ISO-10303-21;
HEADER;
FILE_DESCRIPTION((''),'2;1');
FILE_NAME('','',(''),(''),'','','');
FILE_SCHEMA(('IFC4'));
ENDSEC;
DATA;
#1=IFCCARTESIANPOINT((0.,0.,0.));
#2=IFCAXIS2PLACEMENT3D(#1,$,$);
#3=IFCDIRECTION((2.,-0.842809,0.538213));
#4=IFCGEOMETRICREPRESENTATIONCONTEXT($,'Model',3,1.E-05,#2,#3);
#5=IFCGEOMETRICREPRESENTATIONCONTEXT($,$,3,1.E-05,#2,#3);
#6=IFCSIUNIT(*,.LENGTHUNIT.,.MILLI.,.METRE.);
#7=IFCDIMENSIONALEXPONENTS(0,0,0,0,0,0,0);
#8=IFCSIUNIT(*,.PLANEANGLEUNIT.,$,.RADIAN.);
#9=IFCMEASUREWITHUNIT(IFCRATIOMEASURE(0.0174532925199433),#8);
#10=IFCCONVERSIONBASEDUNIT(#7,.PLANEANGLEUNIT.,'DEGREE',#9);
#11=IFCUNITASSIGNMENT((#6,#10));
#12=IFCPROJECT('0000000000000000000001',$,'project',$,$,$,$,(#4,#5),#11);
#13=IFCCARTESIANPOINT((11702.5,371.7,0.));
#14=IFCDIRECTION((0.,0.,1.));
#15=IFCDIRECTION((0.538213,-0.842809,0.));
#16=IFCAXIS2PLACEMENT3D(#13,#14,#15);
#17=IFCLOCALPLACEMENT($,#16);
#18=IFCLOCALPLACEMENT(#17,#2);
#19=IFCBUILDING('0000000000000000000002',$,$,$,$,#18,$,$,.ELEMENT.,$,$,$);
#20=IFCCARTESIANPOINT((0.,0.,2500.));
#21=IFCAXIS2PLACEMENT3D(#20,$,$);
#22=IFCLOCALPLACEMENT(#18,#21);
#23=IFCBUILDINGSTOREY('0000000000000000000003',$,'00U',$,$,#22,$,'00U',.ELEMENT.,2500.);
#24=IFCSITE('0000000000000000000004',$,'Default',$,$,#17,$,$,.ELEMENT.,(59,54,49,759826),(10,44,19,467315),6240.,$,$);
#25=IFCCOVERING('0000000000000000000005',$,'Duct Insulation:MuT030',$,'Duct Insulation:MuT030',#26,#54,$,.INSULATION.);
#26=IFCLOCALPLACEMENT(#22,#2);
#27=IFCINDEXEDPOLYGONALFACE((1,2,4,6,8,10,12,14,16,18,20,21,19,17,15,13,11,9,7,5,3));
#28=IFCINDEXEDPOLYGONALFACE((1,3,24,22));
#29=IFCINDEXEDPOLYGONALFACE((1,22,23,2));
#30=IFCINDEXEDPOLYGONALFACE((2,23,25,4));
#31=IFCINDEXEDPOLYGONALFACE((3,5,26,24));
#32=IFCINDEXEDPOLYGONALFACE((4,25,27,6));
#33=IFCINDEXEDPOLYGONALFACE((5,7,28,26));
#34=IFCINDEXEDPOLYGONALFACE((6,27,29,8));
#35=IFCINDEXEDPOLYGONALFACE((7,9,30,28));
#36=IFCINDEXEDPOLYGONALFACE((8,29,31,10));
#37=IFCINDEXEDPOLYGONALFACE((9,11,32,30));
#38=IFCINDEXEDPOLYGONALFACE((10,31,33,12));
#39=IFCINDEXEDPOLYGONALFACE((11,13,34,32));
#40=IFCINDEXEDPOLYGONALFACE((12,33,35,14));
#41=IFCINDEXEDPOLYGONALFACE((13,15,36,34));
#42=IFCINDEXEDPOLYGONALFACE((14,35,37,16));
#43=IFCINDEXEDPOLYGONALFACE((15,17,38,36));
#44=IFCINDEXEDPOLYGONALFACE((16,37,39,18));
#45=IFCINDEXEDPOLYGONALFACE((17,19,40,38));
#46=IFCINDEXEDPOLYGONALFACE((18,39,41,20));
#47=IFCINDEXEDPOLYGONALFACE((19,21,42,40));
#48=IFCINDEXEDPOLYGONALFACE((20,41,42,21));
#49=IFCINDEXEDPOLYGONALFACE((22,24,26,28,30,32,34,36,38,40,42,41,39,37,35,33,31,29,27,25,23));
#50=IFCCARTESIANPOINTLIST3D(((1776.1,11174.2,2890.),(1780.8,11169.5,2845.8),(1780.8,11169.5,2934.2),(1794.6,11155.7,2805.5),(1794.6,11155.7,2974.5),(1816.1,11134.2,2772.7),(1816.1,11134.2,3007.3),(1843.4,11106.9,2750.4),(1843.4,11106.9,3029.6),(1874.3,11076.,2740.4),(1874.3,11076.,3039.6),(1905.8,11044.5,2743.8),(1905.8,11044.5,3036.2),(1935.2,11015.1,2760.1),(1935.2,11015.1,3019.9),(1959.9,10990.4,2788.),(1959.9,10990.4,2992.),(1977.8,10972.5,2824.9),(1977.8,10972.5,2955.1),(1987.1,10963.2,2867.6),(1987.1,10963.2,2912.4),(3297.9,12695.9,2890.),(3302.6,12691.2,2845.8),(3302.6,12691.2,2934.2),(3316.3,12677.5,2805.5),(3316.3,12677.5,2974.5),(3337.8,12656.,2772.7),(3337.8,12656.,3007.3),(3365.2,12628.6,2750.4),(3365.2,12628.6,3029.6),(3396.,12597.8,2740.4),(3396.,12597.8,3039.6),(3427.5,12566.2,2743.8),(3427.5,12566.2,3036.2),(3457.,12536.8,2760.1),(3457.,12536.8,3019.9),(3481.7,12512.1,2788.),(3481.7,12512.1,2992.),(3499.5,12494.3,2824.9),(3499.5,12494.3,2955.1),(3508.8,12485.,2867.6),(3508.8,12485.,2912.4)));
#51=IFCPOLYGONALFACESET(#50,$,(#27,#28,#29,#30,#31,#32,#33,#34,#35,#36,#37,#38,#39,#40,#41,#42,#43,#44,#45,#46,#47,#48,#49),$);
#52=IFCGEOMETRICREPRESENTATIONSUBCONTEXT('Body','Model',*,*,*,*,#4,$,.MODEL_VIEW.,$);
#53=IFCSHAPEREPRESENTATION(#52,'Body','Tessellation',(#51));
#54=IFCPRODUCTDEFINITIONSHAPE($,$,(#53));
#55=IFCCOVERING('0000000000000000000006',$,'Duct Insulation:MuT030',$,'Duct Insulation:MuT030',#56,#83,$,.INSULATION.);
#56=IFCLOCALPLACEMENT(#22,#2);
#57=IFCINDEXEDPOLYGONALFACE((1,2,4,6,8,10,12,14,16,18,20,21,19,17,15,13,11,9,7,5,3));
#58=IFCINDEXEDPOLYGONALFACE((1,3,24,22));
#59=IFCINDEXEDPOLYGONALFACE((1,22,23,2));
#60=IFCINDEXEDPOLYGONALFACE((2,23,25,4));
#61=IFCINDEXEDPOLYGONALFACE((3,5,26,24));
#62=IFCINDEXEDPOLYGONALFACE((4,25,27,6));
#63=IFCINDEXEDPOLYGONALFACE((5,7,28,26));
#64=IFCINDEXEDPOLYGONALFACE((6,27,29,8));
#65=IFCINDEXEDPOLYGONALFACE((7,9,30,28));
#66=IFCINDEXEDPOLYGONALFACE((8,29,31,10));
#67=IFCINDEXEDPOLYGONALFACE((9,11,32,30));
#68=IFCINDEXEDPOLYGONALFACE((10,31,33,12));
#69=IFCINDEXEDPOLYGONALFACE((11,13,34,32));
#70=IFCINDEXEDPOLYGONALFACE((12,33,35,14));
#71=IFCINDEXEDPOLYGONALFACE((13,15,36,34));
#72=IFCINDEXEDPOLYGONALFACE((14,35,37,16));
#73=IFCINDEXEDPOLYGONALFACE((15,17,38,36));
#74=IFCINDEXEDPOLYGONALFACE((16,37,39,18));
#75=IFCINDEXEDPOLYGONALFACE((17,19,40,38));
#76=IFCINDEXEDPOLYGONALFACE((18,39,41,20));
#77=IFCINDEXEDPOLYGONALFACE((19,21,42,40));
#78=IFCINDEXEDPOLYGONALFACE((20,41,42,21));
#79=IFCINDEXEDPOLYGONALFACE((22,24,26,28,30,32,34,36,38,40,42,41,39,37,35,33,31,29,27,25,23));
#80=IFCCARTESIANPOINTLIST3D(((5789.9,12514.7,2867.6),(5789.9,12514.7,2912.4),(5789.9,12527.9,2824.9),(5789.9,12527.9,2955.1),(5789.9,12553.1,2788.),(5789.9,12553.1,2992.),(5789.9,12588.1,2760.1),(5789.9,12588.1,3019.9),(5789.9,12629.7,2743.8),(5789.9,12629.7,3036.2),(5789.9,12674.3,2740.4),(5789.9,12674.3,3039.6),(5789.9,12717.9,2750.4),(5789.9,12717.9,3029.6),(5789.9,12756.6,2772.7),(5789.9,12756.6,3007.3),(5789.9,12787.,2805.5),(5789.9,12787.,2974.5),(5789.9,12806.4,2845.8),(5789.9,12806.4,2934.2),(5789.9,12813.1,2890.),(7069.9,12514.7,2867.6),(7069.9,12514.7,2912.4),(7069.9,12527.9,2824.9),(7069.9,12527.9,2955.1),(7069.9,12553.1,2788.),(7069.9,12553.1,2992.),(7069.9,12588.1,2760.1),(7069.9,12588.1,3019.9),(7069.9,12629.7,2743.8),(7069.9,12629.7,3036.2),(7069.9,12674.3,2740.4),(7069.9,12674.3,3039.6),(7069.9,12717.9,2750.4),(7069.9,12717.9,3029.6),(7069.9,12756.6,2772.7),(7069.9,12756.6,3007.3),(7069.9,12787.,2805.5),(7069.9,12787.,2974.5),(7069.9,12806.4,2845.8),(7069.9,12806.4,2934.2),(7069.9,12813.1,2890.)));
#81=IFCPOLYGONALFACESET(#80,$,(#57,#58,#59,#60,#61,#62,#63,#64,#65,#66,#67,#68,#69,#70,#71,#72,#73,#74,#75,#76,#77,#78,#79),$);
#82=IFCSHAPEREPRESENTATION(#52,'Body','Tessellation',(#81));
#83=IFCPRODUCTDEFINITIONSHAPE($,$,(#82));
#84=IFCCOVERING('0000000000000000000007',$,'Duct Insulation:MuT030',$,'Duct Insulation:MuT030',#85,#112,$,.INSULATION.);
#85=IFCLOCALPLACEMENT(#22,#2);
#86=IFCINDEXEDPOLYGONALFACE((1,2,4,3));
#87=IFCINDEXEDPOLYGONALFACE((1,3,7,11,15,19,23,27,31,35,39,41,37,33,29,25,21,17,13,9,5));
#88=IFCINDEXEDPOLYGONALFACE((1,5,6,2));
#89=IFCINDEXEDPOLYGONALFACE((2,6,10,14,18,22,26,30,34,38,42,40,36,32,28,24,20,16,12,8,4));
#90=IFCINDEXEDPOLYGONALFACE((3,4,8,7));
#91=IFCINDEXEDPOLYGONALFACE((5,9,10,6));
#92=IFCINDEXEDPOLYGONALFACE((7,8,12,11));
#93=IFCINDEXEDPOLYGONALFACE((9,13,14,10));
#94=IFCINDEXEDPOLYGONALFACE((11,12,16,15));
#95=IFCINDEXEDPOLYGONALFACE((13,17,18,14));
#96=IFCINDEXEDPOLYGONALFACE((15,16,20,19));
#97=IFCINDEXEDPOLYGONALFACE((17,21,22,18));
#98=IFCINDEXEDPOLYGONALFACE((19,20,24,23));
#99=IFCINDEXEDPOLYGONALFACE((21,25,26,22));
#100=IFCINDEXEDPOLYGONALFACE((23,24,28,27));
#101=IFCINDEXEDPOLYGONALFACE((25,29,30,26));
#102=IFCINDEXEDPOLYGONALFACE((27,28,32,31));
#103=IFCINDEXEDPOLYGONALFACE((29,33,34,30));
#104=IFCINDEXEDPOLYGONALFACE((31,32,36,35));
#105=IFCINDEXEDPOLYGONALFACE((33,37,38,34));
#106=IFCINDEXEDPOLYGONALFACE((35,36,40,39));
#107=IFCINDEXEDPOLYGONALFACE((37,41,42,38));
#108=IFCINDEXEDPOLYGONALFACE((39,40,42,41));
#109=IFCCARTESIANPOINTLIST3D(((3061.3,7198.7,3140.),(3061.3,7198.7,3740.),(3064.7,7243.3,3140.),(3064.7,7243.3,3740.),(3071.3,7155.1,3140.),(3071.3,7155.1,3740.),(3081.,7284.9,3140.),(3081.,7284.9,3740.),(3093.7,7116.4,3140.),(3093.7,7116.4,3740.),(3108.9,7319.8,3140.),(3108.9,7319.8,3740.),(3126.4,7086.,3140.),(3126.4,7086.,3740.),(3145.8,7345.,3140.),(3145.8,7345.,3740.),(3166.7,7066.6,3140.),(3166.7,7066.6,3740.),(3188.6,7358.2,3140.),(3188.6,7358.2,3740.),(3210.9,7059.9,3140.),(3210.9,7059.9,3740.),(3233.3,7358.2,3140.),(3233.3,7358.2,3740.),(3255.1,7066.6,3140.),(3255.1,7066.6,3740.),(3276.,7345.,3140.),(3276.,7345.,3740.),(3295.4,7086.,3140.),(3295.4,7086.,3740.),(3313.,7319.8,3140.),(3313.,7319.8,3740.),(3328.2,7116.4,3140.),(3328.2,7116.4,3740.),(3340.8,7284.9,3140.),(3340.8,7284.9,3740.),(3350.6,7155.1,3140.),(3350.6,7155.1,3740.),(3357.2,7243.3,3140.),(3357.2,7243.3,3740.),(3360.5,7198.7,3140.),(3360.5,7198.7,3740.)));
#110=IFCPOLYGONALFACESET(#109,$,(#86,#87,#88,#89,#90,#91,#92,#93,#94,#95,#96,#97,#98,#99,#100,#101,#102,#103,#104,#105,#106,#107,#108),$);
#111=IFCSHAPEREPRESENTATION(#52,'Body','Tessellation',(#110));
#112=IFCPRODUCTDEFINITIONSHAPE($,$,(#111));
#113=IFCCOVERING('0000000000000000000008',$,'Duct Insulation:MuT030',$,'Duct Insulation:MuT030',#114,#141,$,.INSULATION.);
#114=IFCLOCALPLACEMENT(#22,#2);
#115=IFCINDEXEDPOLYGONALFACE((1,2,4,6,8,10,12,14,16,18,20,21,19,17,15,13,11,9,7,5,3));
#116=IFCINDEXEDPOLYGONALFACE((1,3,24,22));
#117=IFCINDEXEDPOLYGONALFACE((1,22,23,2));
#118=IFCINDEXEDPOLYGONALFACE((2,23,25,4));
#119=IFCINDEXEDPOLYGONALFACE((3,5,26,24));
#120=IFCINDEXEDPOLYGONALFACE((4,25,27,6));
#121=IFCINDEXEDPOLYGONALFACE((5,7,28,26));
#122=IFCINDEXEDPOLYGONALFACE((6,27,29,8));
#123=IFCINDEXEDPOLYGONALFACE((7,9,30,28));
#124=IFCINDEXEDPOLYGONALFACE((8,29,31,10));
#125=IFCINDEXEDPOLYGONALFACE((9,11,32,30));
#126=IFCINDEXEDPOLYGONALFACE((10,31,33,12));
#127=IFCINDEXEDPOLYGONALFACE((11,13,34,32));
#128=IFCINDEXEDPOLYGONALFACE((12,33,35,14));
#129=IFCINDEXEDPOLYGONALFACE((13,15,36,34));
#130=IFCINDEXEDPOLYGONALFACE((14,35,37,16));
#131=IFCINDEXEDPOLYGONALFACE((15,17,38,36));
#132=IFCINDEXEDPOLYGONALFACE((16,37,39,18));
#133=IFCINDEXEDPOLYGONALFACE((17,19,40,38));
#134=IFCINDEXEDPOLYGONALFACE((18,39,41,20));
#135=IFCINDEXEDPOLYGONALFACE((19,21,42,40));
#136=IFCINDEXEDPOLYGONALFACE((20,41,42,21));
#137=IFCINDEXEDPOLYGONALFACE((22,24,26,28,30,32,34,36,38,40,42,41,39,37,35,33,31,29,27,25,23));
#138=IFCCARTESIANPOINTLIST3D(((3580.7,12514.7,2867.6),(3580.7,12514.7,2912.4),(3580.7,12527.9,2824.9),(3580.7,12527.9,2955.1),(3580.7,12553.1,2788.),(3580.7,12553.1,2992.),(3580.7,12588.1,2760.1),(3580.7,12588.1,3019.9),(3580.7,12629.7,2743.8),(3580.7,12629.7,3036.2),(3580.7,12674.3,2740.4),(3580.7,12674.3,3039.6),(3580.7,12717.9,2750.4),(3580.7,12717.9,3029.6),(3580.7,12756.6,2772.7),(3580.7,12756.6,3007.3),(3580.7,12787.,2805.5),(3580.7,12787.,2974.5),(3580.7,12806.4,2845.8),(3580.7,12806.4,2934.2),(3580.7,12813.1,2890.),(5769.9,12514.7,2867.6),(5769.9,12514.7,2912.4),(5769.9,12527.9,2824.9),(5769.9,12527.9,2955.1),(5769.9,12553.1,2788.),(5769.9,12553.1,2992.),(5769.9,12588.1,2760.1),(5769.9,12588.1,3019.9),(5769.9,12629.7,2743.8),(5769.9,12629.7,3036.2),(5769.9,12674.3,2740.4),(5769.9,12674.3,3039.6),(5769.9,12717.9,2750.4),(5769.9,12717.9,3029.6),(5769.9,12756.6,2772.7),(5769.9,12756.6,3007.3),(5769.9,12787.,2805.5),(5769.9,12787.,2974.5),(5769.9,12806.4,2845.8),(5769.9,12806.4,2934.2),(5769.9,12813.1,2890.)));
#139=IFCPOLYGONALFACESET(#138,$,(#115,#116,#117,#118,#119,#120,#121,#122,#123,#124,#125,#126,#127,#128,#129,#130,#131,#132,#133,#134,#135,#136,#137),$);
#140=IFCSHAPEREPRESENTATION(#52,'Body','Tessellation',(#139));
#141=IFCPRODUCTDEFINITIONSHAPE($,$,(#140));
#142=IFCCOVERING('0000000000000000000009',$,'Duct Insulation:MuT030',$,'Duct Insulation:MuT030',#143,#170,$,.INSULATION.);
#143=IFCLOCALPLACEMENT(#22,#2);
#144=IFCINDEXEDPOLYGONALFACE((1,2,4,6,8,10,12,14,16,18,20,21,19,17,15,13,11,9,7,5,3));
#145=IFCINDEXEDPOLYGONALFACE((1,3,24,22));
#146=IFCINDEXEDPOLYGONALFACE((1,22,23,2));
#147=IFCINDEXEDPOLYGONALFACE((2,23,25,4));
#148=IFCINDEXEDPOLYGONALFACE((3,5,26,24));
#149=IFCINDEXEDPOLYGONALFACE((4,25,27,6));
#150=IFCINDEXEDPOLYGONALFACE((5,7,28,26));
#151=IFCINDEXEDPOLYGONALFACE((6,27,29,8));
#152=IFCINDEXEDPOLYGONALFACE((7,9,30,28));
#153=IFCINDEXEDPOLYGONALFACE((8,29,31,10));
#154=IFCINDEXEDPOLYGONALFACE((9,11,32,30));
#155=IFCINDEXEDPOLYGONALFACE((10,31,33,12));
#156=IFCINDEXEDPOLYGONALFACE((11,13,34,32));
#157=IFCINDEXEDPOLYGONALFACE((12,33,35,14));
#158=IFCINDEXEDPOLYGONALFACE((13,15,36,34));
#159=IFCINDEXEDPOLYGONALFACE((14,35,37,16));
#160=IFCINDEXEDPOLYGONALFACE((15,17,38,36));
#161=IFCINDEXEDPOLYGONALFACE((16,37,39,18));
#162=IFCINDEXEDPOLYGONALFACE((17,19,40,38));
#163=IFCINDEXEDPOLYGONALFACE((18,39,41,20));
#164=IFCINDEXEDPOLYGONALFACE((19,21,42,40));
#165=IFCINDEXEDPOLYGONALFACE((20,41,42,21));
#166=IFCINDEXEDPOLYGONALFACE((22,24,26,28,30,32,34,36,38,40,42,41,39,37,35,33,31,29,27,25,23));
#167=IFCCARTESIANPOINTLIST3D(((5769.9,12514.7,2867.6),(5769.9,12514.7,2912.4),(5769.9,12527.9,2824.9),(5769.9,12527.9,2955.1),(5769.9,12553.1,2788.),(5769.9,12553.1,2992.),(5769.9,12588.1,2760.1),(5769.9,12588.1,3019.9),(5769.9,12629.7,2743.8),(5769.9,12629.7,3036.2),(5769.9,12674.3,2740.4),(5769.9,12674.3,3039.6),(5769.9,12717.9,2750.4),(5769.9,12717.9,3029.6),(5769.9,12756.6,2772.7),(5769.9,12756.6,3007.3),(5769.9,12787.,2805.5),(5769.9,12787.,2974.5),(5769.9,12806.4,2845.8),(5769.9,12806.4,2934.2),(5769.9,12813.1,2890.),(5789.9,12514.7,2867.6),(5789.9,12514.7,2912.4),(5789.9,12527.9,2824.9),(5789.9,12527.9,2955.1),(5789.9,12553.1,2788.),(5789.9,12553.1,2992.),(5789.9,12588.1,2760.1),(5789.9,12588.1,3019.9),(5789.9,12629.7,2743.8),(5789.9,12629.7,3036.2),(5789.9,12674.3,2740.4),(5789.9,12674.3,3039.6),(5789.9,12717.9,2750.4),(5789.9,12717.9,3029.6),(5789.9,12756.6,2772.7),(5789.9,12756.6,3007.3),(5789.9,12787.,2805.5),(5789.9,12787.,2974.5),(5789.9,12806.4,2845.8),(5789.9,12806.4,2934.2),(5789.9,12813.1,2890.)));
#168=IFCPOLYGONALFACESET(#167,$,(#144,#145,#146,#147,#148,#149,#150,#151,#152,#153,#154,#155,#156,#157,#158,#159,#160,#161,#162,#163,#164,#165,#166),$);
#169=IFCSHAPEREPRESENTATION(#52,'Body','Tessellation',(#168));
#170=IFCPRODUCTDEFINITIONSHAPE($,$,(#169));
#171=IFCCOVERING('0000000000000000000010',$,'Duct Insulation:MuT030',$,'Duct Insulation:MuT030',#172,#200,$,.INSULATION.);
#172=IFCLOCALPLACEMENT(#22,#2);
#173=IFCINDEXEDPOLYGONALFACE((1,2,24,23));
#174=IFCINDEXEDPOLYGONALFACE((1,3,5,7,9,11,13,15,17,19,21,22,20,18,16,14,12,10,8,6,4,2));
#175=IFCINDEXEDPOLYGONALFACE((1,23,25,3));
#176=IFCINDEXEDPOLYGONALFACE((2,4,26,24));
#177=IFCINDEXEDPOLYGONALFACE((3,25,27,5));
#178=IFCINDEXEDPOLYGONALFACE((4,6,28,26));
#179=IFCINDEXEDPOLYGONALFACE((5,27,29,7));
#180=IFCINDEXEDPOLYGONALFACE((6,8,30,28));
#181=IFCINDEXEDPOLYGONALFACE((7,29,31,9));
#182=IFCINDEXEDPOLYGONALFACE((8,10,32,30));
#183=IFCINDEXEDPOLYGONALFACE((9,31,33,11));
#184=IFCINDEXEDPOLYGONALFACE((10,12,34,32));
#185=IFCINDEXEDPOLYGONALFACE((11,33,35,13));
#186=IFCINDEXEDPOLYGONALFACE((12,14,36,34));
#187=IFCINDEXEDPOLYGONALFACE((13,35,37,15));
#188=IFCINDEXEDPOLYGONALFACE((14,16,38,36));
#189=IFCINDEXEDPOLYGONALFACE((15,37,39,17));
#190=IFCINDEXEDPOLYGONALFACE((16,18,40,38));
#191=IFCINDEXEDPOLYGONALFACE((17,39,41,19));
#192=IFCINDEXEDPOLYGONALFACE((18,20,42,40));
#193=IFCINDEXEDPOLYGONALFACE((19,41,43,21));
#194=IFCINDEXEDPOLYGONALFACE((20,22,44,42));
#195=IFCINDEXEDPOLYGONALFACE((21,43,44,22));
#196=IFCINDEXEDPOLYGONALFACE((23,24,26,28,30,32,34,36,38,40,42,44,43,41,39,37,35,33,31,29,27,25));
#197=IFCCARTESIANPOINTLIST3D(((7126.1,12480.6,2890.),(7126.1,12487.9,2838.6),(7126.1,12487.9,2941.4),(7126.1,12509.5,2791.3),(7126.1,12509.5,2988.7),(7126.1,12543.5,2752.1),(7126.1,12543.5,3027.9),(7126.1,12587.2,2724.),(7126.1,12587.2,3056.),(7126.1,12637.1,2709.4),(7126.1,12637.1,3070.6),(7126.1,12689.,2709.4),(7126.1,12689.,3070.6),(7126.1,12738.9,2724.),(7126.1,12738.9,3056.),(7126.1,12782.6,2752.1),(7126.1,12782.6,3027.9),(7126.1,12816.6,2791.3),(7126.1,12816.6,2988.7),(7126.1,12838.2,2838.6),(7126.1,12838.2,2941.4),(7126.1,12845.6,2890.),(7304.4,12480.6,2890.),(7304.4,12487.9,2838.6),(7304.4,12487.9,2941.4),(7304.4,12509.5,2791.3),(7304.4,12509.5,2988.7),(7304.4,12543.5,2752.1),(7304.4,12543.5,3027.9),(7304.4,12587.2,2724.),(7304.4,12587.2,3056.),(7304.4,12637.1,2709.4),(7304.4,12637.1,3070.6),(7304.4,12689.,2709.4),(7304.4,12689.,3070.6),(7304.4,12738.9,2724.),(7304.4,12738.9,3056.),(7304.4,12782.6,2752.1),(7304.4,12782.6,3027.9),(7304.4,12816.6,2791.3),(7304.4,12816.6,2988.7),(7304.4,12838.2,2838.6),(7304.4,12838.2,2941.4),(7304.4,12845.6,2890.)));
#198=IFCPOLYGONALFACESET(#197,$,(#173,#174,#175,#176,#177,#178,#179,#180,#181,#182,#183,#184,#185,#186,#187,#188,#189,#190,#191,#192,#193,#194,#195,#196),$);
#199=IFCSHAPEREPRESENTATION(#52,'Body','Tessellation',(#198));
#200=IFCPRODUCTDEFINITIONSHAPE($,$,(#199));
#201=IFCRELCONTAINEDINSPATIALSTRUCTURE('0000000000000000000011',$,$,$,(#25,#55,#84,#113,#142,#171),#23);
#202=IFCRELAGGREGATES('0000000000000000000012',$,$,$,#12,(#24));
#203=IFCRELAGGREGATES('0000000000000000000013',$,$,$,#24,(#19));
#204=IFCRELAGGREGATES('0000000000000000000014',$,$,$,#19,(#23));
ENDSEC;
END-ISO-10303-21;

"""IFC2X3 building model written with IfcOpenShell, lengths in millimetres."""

from ifc_helpers import new_model, entity, si_unit, converted_unit, direction, frame, frame_2d, origin, origin_2d_with_axis, place, context, subcontext, project, spatial, circle, extrude, element, save


model = new_model("IFC2X3")

# Units and contexts
model_context = context("Model", 3, precision=1e-05, world=origin(), true_north=direction((2.0, -0.842809, 0.538213)))
context_of_model = context(None, 3, precision=1e-05, world=origin(), true_north=direction((2.0, -0.842809, 0.538213)))
body_context = subcontext(model_context, "Body", "Model", "MODEL_VIEW")
ifc_project = project(units=[si_unit("LENGTHUNIT", "METRE", prefix="MILLI"), converted_unit("PLANEANGLEUNIT", "DEGREE", entity("IfcRatioMeasure", 0.0174532925199433), si_unit("PLANEANGLEUNIT", "RADIAN"), dimensions=[0, 0, 0, 0, 0, 0, 0])], contexts=[model_context, context_of_model])

# Site, building, storey
site_placement = place(None, frame((11702.5, 371.7, 0.0), z_axis=(0.0, 0.0, 1.0), x_axis=(0.538213, -0.842809, 0.0)))
site = spatial("IfcSite", under=ifc_project, at=site_placement, Name="Default", CompositionType="ELEMENT", RefLatitude=(59, 54, 49, 759826), RefLongitude=(10, 44, 19, 467315), RefElevation=6240.0)
building_placement = place(site_placement, origin())
building = spatial("IfcBuilding", under=site, at=building_placement, CompositionType="ELEMENT")
storey_placement = place(building_placement, frame((0.0, 0.0, 2500.0)))
storey = spatial("IfcBuildingStorey", under=building, at=storey_placement, Name="00U", LongName="00U", CompositionType="ELEMENT", Elevation=2500.0)

# Coverings
covering_1_placement = place(storey_placement, origin())
element("IfcCovering", 1, at=covering_1_placement, inside=storey, Name="Duct Insulation:MuT030", ObjectType="Duct Insulation:MuT030", PredefinedType="INSULATION", context=body_context, shape_type="SweptSolid", body=[
    extrude(circle(Radius=150.0, at=frame_2d((0.0, 0.0), x_axis=(1.0, 0.0))), frame((1882.2, 11068.1, 2890.0), z_axis=(0.707107, 0.707107, 0.0), x_axis=(-0.707107, 0.707107, 0.0)), (0.0, 0.0, 1.0), 2152.0),
])
covering_2_placement = place(storey_placement, origin())
element("IfcCovering", 2, at=covering_2_placement, inside=storey, Name="Duct Insulation:MuT030", ObjectType="Duct Insulation:MuT030", PredefinedType="INSULATION", context=body_context, shape_type="SweptSolid", body=[
    extrude(circle(Radius=150.0, at=origin_2d_with_axis()), frame((5789.9, 12663.1, 2890.0), z_axis=(1.0, 0.0, 0.0), x_axis=(0.0, 1.0, 0.0)), (0.0, 0.0, 1.0), 1280.0),
])
covering_3_placement = place(storey_placement, origin())
element("IfcCovering", 3, at=covering_3_placement, inside=storey, Name="Duct Insulation:MuT030", ObjectType="Duct Insulation:MuT030", PredefinedType="INSULATION", context=body_context, shape_type="SweptSolid", body=[
    extrude(circle(Radius=150.0, at=origin_2d_with_axis()), frame((3210.9, 7209.9, 3140.0), z_axis=(0.0, 0.0, 1.0), x_axis=(0.0, -1.0, 0.0)), (0.0, 0.0, 1.0), 600.0),
])
covering_4_placement = place(storey_placement, origin())
element("IfcCovering", 4, at=covering_4_placement, inside=storey, Name="Duct Insulation:MuT030", ObjectType="Duct Insulation:MuT030", PredefinedType="INSULATION", context=body_context, shape_type="SweptSolid", body=[
    extrude(circle(Radius=150.0, at=origin_2d_with_axis()), frame((3580.7, 12663.1, 2890.0), z_axis=(1.0, 0.0, 0.0), x_axis=(0.0, 1.0, 0.0)), (0.0, 0.0, 1.0), 2189.2),
])
covering_5_placement = place(storey_placement, origin())
element("IfcCovering", 5, at=covering_5_placement, inside=storey, Name="Duct Insulation:MuT030", ObjectType="Duct Insulation:MuT030", PredefinedType="INSULATION", context=body_context, shape_type="SweptSolid", body=[
    extrude(circle(Radius=150.0, at=origin_2d_with_axis()), frame((5769.9, 12663.1, 2890.0), z_axis=(1.0, 0.0, 0.0), x_axis=(0.0, 1.0, 0.0)), (0.0, 0.0, 1.0), 20.0),
])
covering_6_placement = place(storey_placement, origin())
element("IfcCovering", 6, at=covering_6_placement, inside=storey, Name="Duct Insulation:MuT030", ObjectType="Duct Insulation:MuT030", PredefinedType="INSULATION", context=body_context, shape_type="SweptSolid", body=[
    extrude(circle(Radius=182.5, at=origin_2d_with_axis()), frame((7126.1, 12663.1, 2890.0), z_axis=(1.0, 0.0, 0.0), x_axis=(0.0, 1.0, 0.0)), (0.0, 0.0, 1.0), 178.3),
])

save(model, "model.ifc")
